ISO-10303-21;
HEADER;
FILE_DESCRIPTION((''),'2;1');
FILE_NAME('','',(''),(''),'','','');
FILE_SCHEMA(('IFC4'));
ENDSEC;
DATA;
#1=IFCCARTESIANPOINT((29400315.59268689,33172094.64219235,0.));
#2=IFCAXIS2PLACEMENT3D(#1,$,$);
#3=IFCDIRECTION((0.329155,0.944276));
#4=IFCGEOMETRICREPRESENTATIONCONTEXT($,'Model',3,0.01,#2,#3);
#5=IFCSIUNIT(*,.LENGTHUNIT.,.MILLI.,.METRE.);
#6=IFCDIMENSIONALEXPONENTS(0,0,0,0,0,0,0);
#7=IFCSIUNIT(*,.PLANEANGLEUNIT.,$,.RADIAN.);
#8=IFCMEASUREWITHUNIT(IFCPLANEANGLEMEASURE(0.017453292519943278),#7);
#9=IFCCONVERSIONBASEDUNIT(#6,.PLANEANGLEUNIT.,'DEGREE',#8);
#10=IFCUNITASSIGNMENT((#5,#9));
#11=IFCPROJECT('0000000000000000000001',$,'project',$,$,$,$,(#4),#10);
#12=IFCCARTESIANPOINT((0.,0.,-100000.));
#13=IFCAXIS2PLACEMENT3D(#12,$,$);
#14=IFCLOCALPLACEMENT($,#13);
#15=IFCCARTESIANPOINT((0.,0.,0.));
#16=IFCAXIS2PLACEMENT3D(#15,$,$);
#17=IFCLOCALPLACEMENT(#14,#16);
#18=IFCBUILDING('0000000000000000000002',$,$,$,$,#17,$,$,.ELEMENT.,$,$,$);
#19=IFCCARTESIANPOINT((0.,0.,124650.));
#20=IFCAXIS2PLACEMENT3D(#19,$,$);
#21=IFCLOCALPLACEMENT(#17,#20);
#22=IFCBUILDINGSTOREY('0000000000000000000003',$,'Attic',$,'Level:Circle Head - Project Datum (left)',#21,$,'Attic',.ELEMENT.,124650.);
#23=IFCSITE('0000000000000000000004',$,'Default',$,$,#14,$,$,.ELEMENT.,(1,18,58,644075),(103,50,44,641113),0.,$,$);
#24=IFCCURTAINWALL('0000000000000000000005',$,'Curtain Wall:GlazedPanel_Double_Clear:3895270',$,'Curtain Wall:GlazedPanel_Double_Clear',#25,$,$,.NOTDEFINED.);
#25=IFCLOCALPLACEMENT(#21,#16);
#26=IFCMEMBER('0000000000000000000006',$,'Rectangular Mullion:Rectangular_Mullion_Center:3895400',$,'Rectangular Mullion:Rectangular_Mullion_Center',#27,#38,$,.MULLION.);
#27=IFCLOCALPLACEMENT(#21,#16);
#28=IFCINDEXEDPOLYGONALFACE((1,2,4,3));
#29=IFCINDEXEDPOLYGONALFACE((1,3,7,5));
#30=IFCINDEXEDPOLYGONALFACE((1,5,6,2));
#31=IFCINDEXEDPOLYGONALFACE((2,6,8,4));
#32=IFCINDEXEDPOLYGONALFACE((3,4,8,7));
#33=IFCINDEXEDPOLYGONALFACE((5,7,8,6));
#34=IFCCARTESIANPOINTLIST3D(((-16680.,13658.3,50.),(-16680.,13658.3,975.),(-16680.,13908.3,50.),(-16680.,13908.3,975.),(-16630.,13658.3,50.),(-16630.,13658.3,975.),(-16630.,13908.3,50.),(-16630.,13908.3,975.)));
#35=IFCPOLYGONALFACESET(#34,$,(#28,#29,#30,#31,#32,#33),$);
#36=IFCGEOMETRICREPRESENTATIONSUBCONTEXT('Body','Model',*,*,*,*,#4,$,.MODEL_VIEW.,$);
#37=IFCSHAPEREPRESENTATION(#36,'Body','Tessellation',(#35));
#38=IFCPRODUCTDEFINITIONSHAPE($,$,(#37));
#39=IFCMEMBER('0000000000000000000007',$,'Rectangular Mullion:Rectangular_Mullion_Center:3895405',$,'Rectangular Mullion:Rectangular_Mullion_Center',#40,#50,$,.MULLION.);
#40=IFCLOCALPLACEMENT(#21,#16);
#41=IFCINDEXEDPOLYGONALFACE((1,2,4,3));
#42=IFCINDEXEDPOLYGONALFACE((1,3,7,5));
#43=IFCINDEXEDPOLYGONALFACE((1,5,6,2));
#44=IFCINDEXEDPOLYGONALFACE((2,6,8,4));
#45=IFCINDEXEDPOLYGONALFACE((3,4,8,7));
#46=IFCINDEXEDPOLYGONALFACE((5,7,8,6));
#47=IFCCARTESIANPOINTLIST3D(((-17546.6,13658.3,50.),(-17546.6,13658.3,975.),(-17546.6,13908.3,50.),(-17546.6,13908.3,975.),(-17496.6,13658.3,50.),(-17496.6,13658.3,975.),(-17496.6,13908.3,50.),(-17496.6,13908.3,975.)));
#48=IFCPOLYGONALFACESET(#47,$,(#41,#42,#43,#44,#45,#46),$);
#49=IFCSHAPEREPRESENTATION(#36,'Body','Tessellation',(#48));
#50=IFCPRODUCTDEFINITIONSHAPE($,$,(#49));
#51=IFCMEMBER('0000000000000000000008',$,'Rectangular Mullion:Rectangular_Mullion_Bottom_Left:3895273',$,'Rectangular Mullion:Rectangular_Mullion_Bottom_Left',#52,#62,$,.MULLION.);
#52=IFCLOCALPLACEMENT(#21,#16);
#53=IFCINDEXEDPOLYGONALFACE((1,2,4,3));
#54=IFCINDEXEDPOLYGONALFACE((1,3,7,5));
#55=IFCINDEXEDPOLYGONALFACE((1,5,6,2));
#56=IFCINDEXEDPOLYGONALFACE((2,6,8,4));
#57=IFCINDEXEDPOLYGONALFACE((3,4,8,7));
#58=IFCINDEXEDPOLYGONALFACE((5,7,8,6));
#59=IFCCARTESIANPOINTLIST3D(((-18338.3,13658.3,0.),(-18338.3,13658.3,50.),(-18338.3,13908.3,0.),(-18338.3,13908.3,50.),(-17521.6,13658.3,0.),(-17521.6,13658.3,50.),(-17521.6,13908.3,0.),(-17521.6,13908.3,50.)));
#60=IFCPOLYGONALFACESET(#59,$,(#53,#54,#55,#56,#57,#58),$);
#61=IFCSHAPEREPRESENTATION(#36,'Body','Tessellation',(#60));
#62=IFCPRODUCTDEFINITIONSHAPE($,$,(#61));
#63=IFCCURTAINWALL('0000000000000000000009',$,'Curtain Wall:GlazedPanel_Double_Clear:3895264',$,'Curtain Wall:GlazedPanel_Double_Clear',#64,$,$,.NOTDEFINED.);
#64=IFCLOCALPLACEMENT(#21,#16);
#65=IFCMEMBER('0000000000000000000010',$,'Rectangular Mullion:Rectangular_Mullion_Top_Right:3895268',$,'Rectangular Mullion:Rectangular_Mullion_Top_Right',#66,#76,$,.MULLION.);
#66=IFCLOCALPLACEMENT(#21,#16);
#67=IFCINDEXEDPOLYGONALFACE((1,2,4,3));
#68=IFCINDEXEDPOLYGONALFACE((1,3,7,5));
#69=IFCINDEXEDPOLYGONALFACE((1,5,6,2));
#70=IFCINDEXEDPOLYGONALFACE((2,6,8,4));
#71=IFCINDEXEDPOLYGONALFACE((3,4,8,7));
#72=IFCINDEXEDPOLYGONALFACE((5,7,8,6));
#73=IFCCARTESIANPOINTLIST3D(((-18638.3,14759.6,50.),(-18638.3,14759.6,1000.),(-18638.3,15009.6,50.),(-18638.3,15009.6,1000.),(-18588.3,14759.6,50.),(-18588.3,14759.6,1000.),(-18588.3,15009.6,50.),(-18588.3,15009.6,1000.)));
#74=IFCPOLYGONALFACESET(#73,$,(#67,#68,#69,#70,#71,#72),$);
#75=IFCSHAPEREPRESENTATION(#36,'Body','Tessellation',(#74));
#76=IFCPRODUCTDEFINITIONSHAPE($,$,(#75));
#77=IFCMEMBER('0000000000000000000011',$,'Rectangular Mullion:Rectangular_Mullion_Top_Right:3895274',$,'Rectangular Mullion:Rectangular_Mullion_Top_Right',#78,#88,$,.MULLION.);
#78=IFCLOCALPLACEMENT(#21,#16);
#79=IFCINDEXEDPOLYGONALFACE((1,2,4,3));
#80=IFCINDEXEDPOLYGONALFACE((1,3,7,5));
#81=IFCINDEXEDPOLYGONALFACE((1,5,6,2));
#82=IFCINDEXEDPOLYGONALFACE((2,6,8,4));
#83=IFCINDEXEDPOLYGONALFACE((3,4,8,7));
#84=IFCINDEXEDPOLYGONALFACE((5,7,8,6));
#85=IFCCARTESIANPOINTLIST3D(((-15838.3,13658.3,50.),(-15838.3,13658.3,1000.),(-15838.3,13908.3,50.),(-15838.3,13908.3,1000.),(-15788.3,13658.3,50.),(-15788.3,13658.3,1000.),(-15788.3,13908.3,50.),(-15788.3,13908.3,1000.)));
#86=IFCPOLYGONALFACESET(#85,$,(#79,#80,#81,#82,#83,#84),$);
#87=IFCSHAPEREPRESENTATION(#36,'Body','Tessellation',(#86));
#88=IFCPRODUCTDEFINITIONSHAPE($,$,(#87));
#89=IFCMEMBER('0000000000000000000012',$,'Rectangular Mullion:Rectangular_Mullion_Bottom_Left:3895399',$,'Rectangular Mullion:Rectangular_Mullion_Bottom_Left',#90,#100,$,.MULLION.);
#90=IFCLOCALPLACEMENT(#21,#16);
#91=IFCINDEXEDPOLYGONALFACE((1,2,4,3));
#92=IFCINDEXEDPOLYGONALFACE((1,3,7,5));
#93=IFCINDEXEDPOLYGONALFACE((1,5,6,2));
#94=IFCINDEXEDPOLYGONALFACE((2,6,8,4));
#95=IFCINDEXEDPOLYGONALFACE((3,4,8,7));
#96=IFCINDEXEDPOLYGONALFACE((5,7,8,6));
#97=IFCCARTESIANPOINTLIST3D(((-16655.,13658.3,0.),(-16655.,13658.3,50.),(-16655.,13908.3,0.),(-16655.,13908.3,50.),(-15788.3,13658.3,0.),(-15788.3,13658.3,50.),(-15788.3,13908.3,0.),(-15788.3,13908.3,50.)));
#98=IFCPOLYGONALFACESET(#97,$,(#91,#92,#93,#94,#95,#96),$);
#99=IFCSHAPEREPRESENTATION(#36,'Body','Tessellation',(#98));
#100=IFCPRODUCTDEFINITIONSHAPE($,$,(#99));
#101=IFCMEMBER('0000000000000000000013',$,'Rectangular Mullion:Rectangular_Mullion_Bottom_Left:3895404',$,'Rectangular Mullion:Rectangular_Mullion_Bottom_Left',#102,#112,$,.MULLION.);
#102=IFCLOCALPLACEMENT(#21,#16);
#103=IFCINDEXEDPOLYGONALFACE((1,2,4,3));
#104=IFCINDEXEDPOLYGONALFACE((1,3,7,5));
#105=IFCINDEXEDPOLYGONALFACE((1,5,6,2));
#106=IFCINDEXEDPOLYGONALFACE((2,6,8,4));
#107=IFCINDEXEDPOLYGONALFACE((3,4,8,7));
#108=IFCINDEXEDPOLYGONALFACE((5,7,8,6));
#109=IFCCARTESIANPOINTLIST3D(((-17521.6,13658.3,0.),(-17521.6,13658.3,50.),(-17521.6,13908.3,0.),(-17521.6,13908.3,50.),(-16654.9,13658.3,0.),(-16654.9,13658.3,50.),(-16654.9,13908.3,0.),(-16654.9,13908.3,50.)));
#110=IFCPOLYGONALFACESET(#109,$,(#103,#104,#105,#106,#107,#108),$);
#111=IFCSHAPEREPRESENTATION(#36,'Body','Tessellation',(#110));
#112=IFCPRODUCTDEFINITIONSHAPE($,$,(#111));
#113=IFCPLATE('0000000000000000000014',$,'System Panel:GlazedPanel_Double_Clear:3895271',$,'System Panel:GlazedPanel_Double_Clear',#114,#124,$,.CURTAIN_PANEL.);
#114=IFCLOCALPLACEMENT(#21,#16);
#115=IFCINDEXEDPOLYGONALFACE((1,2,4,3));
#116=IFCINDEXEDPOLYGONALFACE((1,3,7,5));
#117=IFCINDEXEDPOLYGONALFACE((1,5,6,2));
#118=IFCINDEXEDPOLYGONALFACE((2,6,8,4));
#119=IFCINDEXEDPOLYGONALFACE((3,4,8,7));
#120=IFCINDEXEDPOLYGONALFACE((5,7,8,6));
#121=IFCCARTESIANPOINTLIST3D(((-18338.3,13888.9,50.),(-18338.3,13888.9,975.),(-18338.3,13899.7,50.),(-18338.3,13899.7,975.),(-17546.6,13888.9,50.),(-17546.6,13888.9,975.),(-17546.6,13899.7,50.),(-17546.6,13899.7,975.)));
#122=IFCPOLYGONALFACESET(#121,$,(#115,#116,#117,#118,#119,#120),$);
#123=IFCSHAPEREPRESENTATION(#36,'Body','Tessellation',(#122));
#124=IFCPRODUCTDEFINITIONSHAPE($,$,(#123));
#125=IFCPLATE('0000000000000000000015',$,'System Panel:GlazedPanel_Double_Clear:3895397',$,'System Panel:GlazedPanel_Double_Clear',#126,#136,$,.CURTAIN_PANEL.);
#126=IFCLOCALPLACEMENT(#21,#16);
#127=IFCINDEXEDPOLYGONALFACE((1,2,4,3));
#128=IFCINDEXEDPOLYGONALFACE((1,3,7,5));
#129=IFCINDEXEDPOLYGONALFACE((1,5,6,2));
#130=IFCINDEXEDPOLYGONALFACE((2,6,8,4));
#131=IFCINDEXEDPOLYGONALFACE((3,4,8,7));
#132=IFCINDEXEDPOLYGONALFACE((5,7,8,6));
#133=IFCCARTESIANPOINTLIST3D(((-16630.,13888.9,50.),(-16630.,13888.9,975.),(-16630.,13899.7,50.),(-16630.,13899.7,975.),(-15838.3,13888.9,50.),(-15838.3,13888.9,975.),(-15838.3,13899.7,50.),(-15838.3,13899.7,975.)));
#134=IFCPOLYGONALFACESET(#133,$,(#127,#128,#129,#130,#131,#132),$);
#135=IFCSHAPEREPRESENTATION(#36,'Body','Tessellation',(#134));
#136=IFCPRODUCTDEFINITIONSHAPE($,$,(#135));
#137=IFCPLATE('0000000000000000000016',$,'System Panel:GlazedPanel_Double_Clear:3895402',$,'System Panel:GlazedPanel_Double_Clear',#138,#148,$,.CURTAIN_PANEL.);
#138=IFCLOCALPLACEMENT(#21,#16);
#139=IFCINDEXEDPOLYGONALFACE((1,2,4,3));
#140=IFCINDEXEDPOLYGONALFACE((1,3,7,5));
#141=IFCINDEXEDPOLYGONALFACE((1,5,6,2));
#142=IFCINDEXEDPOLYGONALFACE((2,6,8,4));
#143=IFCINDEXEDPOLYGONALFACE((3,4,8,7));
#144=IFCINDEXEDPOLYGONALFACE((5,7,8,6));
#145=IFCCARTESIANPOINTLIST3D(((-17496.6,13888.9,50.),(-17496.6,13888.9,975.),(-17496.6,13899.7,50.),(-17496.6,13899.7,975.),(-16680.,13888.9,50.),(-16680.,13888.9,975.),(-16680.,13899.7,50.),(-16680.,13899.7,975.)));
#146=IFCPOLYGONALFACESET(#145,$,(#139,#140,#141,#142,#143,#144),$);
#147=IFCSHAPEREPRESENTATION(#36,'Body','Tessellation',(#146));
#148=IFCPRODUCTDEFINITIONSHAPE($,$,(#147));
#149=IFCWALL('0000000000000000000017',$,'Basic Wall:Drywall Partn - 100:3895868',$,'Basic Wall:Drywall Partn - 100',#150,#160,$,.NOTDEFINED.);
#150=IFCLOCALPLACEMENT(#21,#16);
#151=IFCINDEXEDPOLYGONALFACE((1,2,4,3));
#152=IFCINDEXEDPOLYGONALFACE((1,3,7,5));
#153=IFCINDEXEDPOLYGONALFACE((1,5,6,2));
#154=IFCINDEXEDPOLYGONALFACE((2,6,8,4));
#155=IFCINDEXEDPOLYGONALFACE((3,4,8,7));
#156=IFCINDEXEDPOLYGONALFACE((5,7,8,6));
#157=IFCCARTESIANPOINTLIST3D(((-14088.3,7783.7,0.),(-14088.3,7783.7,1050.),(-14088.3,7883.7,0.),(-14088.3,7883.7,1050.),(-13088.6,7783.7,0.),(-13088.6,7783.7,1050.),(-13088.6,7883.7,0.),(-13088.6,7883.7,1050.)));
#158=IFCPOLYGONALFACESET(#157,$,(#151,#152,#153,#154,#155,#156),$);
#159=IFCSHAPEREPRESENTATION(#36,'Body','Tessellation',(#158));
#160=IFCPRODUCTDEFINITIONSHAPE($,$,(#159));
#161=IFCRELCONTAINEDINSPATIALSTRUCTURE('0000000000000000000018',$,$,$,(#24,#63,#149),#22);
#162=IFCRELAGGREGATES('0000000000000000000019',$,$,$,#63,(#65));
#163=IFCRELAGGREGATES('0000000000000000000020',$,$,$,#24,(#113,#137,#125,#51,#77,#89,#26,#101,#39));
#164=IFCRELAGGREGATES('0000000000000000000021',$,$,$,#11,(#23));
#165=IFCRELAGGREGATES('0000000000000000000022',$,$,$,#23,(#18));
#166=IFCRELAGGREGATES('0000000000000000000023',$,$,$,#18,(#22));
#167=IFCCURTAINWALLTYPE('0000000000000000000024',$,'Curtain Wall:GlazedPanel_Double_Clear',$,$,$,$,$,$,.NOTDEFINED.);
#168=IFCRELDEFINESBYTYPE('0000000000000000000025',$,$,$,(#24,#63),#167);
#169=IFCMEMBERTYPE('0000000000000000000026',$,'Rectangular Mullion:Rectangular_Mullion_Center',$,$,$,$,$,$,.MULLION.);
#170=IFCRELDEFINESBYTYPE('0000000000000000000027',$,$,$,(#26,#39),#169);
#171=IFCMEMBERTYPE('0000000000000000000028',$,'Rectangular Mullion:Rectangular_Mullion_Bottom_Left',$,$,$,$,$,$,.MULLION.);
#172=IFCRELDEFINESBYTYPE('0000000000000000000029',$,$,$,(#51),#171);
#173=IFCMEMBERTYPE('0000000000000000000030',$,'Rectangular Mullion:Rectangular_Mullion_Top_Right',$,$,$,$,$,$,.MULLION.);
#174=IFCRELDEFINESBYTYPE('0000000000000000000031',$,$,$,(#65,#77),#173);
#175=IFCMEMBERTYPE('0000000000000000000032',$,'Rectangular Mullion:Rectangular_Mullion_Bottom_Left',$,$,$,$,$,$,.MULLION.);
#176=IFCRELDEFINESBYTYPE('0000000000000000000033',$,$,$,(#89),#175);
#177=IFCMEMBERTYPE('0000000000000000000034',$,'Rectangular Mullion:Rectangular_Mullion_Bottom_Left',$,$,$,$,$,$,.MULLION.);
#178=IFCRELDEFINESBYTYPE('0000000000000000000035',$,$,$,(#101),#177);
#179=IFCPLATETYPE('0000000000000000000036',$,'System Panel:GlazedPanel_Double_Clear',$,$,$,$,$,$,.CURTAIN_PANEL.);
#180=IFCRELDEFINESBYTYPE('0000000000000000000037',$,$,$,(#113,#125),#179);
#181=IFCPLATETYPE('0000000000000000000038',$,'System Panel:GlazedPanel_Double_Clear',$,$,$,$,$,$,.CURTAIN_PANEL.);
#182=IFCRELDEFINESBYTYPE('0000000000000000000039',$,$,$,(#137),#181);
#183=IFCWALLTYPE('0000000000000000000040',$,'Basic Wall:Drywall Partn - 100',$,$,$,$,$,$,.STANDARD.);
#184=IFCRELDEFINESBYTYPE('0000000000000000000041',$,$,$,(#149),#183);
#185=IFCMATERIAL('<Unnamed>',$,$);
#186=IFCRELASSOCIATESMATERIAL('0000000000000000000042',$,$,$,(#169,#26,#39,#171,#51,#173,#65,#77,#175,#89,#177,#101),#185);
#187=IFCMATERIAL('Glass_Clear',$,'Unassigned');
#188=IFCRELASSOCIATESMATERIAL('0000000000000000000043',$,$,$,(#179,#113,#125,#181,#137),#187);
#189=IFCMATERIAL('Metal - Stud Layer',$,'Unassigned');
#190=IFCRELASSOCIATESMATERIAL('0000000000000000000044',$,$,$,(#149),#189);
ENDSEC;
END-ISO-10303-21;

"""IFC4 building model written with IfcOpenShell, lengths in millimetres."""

from ifc_helpers import new_model, entity, si_unit, converted_unit, direction, frame, origin, place, context, subcontext, project, spatial, indexed_curve, outline, extrude, source, transform, mapped, material, type_object, type_shapes, element, aggregate, save


model = new_model("IFC4")

# Units and contexts
model_context = context("Model", 3, precision=0.01, world=frame((29400315.59268689, 33172094.64219235, 0.0)), true_north=direction((0.329155, 0.944276)))
body_context = subcontext(model_context, "Body", "Model", "MODEL_VIEW")
ifc_project = project(units=[si_unit("LENGTHUNIT", "METRE", prefix="MILLI"), converted_unit("PLANEANGLEUNIT", "DEGREE", entity("IfcPlaneAngleMeasure", 0.017453292519943278), si_unit("PLANEANGLEUNIT", "RADIAN"), dimensions=[0, 0, 0, 0, 0, 0, 0])], contexts=[model_context])

# Site, building, storey
site_placement = place(None, frame((0.0, 0.0, -100000.0)))
site = spatial("IfcSite", under=ifc_project, at=site_placement, Name="Default", CompositionType="ELEMENT", RefLatitude=(1, 18, 58, 644075), RefLongitude=(103, 50, 44, 641113), RefElevation=0.0)
building_placement = place(site_placement, origin())
building = spatial("IfcBuilding", under=site, at=building_placement, CompositionType="ELEMENT")
storey_placement = place(building_placement, frame((0.0, 0.0, 124650.0)))
storey = spatial("IfcBuildingStorey", under=building, at=storey_placement, Name="Attic", ObjectType="Level:Circle Head - Project Datum (left)", LongName="Attic", CompositionType="ELEMENT", Elevation=124650.0)

# Curtain wall, members
curtain_wall_type = type_object("IfcCurtainWallType", Name="Curtain Wall:GlazedPanel_Double_Clear", PredefinedType="NOTDEFINED")
curtain_wall_1_placement = place(storey_placement, frame((0.0, 0.0, -124650.0)))
curtain_wall_1 = element("IfcCurtainWall", 1, at=curtain_wall_1_placement, inside=storey, type_object=curtain_wall_type, Name="Curtain Wall:GlazedPanel_Double_Clear:3895270", ObjectType="Curtain Wall:GlazedPanel_Double_Clear", PredefinedType="NOTDEFINED")
ifc_material_1 = material(Name="<Unnamed>")
member_type_1 = type_object("IfcMemberType", Name="Rectangular Mullion:Rectangular_Mullion_Center", PredefinedType="MULLION", material=ifc_material_1)
shared_shape_1 = source(origin(), body_context, "Body", "SweptSolid", [
    extrude(outline(indexed_curve([(-25.0, -125.0), (25.0, -125.0), (25.0, 125.0), (-25.0, 125.0), (-25.0, -125.0)], self_intersect=False)), frame((0.0, 0.0, -925.0), z_axis=(0.0, 0.0, 1.0), x_axis=(-1.0, 0.0, 0.0)), (0.0, 0.0, 1.0), 925.0),
])
type_shapes(member_type_1, [shared_shape_1])
member_1_placement = place(curtain_wall_1_placement, frame((-16655.0, 13783.3, 124700.0), z_axis=(0.0, 0.0, -1.0), x_axis=(1.0, 0.0, 0.0)))
member_1 = element("IfcMember", 2, at=member_1_placement, type_object=member_type_1, material=ifc_material_1, Name="Rectangular Mullion:Rectangular_Mullion_Center:3895400", ObjectType="Rectangular Mullion:Rectangular_Mullion_Center", PredefinedType="MULLION", context=body_context, shape_type="MappedRepresentation", body=[
    mapped(shared_shape_1, transform((0.0, 0.0, 0.0), scale=1.0)),
])
member_2_placement = place(curtain_wall_1_placement, frame((-17521.6, 13783.3, 124700.0), z_axis=(0.0, 0.0, -1.0), x_axis=(1.0, 0.0, 0.0)))
member_2 = element("IfcMember", 3, at=member_2_placement, type_object=member_type_1, material=ifc_material_1, Name="Rectangular Mullion:Rectangular_Mullion_Center:3895405", ObjectType="Rectangular Mullion:Rectangular_Mullion_Center", PredefinedType="MULLION", context=body_context, shape_type="MappedRepresentation", body=[
    mapped(shared_shape_1, transform((0.0, 0.0, 0.0), scale=1.0)),
])
member_type_2 = type_object("IfcMemberType", Name="Rectangular Mullion:Rectangular_Mullion_Bottom_Left", PredefinedType="MULLION", material=ifc_material_1)
shared_shape_2 = source(origin(), body_context, "Body", "SweptSolid", [
    extrude(outline(indexed_curve([(-25.0, -125.0), (25.0, -125.0), (25.0, 125.0), (-25.0, 125.0), (-25.0, -125.0)], self_intersect=False)), frame((-25.0, 0.0, -816.7), z_axis=(0.0, 0.0, 1.0), x_axis=(-1.0, 0.0, 0.0)), (0.0, 0.0, 1.0), 816.7),
])
type_shapes(member_type_2, [shared_shape_2])
member_3_placement = place(curtain_wall_1_placement, frame((-18338.3, 13783.3, 124650.0), z_axis=(-1.0, 0.0, 0.0), x_axis=(0.0, 0.0, -1.0)))
member_3 = element("IfcMember", 4, at=member_3_placement, type_object=member_type_2, material=ifc_material_1, Name="Rectangular Mullion:Rectangular_Mullion_Bottom_Left:3895273", ObjectType="Rectangular Mullion:Rectangular_Mullion_Bottom_Left", PredefinedType="MULLION", context=body_context, shape_type="MappedRepresentation", body=[
    mapped(shared_shape_2, transform((0.0, 0.0, 0.0), scale=1.0)),
])

# Curtain wall, member
curtain_wall_2_placement = place(storey_placement, frame((0.0, 0.0, -124650.0)))
curtain_wall_2 = element("IfcCurtainWall", 5, at=curtain_wall_2_placement, inside=storey, type_object=curtain_wall_type, Name="Curtain Wall:GlazedPanel_Double_Clear:3895264", ObjectType="Curtain Wall:GlazedPanel_Double_Clear", PredefinedType="NOTDEFINED")
member_type_3 = type_object("IfcMemberType", Name="Rectangular Mullion:Rectangular_Mullion_Top_Right", PredefinedType="MULLION", material=ifc_material_1)
shared_shape_3 = source(origin(), body_context, "Body", "SweptSolid", [
    extrude(outline(indexed_curve([(-25.0, -125.0), (25.0, -125.0), (25.0, 125.0), (-25.0, 125.0), (-25.0, -125.0)], self_intersect=False)), frame((-25.0, 0.0, -950.0), z_axis=(0.0, 0.0, 1.0), x_axis=(-1.0, 0.0, 0.0)), (0.0, 0.0, 1.0), 950.0),
])
type_shapes(member_type_3, [shared_shape_3])
member_4_placement = place(curtain_wall_2_placement, frame((-18588.3, 14884.6, 124700.0), z_axis=(0.0, 0.0, -1.0), x_axis=(1.0, 0.0, 0.0)))
member_4 = element("IfcMember", 6, at=member_4_placement, type_object=member_type_3, material=ifc_material_1, Name="Rectangular Mullion:Rectangular_Mullion_Top_Right:3895268", ObjectType="Rectangular Mullion:Rectangular_Mullion_Top_Right", PredefinedType="MULLION", context=body_context, shape_type="MappedRepresentation", body=[
    mapped(shared_shape_3, transform((0.0, 0.0, 0.0), scale=1.0)),
])
aggregate(curtain_wall_2, [member_4])

# Members
member_5_placement = place(curtain_wall_1_placement, frame((-15788.3, 13783.3, 124700.0), z_axis=(0.0, 0.0, -1.0), x_axis=(1.0, 0.0, 0.0)))
member_5 = element("IfcMember", 7, at=member_5_placement, type_object=member_type_3, material=ifc_material_1, Name="Rectangular Mullion:Rectangular_Mullion_Top_Right:3895274", ObjectType="Rectangular Mullion:Rectangular_Mullion_Top_Right", PredefinedType="MULLION", context=body_context, shape_type="MappedRepresentation", body=[
    mapped(shared_shape_3, transform((0.0, 0.0, 0.0), scale=1.0)),
])
member_type_4 = type_object("IfcMemberType", Name="Rectangular Mullion:Rectangular_Mullion_Bottom_Left", PredefinedType="MULLION", material=ifc_material_1)
shared_shape_4 = source(origin(), body_context, "Body", "SweptSolid", [
    extrude(outline(indexed_curve([(-25.0, -125.0), (25.0, -125.0), (25.0, 125.0), (-25.0, 125.0), (-25.0, -125.0)], self_intersect=False)), frame((-25.0, 0.0, -866.7), z_axis=(0.0, 0.0, 1.0), x_axis=(-1.0, 0.0, 0.0)), (0.0, 0.0, 1.0), 866.7),
])
type_shapes(member_type_4, [shared_shape_4])
member_6_placement = place(curtain_wall_1_placement, frame((-16655.0, 13783.3, 124650.0), z_axis=(-1.0, 0.0, 0.0), x_axis=(0.0, 0.0, -1.0)))
member_6 = element("IfcMember", 8, at=member_6_placement, type_object=member_type_4, material=ifc_material_1, Name="Rectangular Mullion:Rectangular_Mullion_Bottom_Left:3895399", ObjectType="Rectangular Mullion:Rectangular_Mullion_Bottom_Left", PredefinedType="MULLION", context=body_context, shape_type="MappedRepresentation", body=[
    mapped(shared_shape_4, transform((0.0, 0.0, 0.0), scale=1.0)),
])
member_type_5 = type_object("IfcMemberType", Name="Rectangular Mullion:Rectangular_Mullion_Bottom_Left", PredefinedType="MULLION", material=ifc_material_1)
shared_shape_5 = source(origin(), body_context, "Body", "SweptSolid", [
    extrude(outline(indexed_curve([(-25.0, -125.0), (25.0, -125.0), (25.0, 125.0), (-25.0, 125.0), (-25.0, -125.0)], self_intersect=False)), frame((-25.0, 0.0, -866.7), z_axis=(0.0, 0.0, 1.0), x_axis=(-1.0, 0.0, 0.0)), (0.0, 0.0, 1.0), 866.7),
])
type_shapes(member_type_5, [shared_shape_5])
member_7_placement = place(curtain_wall_1_placement, frame((-17521.6, 13783.3, 124650.0), z_axis=(-1.0, 0.0, 0.0), x_axis=(0.0, 0.0, -1.0)))
member_7 = element("IfcMember", 9, at=member_7_placement, type_object=member_type_5, material=ifc_material_1, Name="Rectangular Mullion:Rectangular_Mullion_Bottom_Left:3895404", ObjectType="Rectangular Mullion:Rectangular_Mullion_Bottom_Left", PredefinedType="MULLION", context=body_context, shape_type="MappedRepresentation", body=[
    mapped(shared_shape_5, transform((0.0, 0.0, 0.0), scale=1.0)),
])

# Plates
ifc_material_2 = material(Name="Glass_Clear", Category="Unassigned")
plate_type_1 = type_object("IfcPlateType", Name="System Panel:GlazedPanel_Double_Clear", PredefinedType="CURTAIN_PANEL", material=ifc_material_2)
shared_shape_6 = source(origin(), body_context, "Body", "SweptSolid", [
    extrude(outline(indexed_curve([(-5.4, -395.8), (5.4, -395.8), (5.4, 395.8), (-5.4, 395.8), (-5.4, -395.8)], self_intersect=False)), frame((0.0, 111.0, 0.0), z_axis=(0.0, 0.0, 1.0), x_axis=(0.0, 1.0, 0.0)), (0.0, 0.0, 1.0), 925.0),
])
type_shapes(plate_type_1, [shared_shape_6])
plate_1_placement = place(curtain_wall_1_placement, frame((-17942.4, 13783.3, 124700.0)))
plate_1 = element("IfcPlate", 10, at=plate_1_placement, type_object=plate_type_1, material=ifc_material_2, Name="System Panel:GlazedPanel_Double_Clear:3895271", ObjectType="System Panel:GlazedPanel_Double_Clear", PredefinedType="CURTAIN_PANEL", context=body_context, shape_type="MappedRepresentation", body=[
    mapped(shared_shape_6, transform((0.0, 0.0, 0.0), scale=1.0)),
])
plate_2_placement = place(curtain_wall_1_placement, frame((-16234.2, 13783.3, 124700.0)))
plate_2 = element("IfcPlate", 11, at=plate_2_placement, type_object=plate_type_1, material=ifc_material_2, Name="System Panel:GlazedPanel_Double_Clear:3895397", ObjectType="System Panel:GlazedPanel_Double_Clear", PredefinedType="CURTAIN_PANEL", context=body_context, shape_type="MappedRepresentation", body=[
    mapped(shared_shape_6, transform((0.0, 0.0, 0.0), scale=1.0)),
])
plate_type_2 = type_object("IfcPlateType", Name="System Panel:GlazedPanel_Double_Clear", PredefinedType="CURTAIN_PANEL", material=ifc_material_2)
shared_shape_7 = source(origin(), body_context, "Body", "SweptSolid", [
    extrude(outline(indexed_curve([(-5.4, -408.3), (5.4, -408.3), (5.4, 408.3), (-5.4, 408.3), (-5.4, -408.3)], self_intersect=False)), frame((0.0, 111.0, 0.0), z_axis=(0.0, 0.0, 1.0), x_axis=(0.0, 1.0, 0.0)), (0.0, 0.0, 1.0), 925.0),
])
type_shapes(plate_type_2, [shared_shape_7])
plate_3_placement = place(curtain_wall_1_placement, frame((-17088.3, 13783.3, 124700.0)))
plate_3 = element("IfcPlate", 12, at=plate_3_placement, type_object=plate_type_2, material=ifc_material_2, Name="System Panel:GlazedPanel_Double_Clear:3895402", ObjectType="System Panel:GlazedPanel_Double_Clear", PredefinedType="CURTAIN_PANEL", context=body_context, shape_type="MappedRepresentation", body=[
    mapped(shared_shape_7, transform((0.0, 0.0, 0.0), scale=1.0)),
])
aggregate(curtain_wall_1, [plate_1, plate_3, plate_2, member_3, member_5, member_6, member_1, member_7, member_2])

# Wall
ifc_material_3 = material(Name="Metal - Stud Layer", Category="Unassigned")
wall_type_1 = type_object("IfcWallType", Name="Basic Wall:Drywall Partn - 100", PredefinedType="STANDARD")
wall_1_placement = place(storey_placement, frame((-13088.6, 7833.7, 0.0), z_axis=(0.0, 0.0, 1.0), x_axis=(-1.0, 0.0, 0.0)))
element("IfcWall", 13, at=wall_1_placement, inside=storey, type_object=wall_type_1, material=ifc_material_3, Name="Basic Wall:Drywall Partn - 100:3895868", ObjectType="Basic Wall:Drywall Partn - 100", PredefinedType="NOTDEFINED", context=body_context, shape_type="SweptSolid", body=[
    extrude(outline(indexed_curve([(999.7, 50.0), (0.0, 50.0), (0.0, -50.0), (999.7, -50.0), (999.7, 50.0)], self_intersect=False)), origin(), (0.0, 0.0, 1.0), 1050.0),
])

save(model, "model.ifc")
